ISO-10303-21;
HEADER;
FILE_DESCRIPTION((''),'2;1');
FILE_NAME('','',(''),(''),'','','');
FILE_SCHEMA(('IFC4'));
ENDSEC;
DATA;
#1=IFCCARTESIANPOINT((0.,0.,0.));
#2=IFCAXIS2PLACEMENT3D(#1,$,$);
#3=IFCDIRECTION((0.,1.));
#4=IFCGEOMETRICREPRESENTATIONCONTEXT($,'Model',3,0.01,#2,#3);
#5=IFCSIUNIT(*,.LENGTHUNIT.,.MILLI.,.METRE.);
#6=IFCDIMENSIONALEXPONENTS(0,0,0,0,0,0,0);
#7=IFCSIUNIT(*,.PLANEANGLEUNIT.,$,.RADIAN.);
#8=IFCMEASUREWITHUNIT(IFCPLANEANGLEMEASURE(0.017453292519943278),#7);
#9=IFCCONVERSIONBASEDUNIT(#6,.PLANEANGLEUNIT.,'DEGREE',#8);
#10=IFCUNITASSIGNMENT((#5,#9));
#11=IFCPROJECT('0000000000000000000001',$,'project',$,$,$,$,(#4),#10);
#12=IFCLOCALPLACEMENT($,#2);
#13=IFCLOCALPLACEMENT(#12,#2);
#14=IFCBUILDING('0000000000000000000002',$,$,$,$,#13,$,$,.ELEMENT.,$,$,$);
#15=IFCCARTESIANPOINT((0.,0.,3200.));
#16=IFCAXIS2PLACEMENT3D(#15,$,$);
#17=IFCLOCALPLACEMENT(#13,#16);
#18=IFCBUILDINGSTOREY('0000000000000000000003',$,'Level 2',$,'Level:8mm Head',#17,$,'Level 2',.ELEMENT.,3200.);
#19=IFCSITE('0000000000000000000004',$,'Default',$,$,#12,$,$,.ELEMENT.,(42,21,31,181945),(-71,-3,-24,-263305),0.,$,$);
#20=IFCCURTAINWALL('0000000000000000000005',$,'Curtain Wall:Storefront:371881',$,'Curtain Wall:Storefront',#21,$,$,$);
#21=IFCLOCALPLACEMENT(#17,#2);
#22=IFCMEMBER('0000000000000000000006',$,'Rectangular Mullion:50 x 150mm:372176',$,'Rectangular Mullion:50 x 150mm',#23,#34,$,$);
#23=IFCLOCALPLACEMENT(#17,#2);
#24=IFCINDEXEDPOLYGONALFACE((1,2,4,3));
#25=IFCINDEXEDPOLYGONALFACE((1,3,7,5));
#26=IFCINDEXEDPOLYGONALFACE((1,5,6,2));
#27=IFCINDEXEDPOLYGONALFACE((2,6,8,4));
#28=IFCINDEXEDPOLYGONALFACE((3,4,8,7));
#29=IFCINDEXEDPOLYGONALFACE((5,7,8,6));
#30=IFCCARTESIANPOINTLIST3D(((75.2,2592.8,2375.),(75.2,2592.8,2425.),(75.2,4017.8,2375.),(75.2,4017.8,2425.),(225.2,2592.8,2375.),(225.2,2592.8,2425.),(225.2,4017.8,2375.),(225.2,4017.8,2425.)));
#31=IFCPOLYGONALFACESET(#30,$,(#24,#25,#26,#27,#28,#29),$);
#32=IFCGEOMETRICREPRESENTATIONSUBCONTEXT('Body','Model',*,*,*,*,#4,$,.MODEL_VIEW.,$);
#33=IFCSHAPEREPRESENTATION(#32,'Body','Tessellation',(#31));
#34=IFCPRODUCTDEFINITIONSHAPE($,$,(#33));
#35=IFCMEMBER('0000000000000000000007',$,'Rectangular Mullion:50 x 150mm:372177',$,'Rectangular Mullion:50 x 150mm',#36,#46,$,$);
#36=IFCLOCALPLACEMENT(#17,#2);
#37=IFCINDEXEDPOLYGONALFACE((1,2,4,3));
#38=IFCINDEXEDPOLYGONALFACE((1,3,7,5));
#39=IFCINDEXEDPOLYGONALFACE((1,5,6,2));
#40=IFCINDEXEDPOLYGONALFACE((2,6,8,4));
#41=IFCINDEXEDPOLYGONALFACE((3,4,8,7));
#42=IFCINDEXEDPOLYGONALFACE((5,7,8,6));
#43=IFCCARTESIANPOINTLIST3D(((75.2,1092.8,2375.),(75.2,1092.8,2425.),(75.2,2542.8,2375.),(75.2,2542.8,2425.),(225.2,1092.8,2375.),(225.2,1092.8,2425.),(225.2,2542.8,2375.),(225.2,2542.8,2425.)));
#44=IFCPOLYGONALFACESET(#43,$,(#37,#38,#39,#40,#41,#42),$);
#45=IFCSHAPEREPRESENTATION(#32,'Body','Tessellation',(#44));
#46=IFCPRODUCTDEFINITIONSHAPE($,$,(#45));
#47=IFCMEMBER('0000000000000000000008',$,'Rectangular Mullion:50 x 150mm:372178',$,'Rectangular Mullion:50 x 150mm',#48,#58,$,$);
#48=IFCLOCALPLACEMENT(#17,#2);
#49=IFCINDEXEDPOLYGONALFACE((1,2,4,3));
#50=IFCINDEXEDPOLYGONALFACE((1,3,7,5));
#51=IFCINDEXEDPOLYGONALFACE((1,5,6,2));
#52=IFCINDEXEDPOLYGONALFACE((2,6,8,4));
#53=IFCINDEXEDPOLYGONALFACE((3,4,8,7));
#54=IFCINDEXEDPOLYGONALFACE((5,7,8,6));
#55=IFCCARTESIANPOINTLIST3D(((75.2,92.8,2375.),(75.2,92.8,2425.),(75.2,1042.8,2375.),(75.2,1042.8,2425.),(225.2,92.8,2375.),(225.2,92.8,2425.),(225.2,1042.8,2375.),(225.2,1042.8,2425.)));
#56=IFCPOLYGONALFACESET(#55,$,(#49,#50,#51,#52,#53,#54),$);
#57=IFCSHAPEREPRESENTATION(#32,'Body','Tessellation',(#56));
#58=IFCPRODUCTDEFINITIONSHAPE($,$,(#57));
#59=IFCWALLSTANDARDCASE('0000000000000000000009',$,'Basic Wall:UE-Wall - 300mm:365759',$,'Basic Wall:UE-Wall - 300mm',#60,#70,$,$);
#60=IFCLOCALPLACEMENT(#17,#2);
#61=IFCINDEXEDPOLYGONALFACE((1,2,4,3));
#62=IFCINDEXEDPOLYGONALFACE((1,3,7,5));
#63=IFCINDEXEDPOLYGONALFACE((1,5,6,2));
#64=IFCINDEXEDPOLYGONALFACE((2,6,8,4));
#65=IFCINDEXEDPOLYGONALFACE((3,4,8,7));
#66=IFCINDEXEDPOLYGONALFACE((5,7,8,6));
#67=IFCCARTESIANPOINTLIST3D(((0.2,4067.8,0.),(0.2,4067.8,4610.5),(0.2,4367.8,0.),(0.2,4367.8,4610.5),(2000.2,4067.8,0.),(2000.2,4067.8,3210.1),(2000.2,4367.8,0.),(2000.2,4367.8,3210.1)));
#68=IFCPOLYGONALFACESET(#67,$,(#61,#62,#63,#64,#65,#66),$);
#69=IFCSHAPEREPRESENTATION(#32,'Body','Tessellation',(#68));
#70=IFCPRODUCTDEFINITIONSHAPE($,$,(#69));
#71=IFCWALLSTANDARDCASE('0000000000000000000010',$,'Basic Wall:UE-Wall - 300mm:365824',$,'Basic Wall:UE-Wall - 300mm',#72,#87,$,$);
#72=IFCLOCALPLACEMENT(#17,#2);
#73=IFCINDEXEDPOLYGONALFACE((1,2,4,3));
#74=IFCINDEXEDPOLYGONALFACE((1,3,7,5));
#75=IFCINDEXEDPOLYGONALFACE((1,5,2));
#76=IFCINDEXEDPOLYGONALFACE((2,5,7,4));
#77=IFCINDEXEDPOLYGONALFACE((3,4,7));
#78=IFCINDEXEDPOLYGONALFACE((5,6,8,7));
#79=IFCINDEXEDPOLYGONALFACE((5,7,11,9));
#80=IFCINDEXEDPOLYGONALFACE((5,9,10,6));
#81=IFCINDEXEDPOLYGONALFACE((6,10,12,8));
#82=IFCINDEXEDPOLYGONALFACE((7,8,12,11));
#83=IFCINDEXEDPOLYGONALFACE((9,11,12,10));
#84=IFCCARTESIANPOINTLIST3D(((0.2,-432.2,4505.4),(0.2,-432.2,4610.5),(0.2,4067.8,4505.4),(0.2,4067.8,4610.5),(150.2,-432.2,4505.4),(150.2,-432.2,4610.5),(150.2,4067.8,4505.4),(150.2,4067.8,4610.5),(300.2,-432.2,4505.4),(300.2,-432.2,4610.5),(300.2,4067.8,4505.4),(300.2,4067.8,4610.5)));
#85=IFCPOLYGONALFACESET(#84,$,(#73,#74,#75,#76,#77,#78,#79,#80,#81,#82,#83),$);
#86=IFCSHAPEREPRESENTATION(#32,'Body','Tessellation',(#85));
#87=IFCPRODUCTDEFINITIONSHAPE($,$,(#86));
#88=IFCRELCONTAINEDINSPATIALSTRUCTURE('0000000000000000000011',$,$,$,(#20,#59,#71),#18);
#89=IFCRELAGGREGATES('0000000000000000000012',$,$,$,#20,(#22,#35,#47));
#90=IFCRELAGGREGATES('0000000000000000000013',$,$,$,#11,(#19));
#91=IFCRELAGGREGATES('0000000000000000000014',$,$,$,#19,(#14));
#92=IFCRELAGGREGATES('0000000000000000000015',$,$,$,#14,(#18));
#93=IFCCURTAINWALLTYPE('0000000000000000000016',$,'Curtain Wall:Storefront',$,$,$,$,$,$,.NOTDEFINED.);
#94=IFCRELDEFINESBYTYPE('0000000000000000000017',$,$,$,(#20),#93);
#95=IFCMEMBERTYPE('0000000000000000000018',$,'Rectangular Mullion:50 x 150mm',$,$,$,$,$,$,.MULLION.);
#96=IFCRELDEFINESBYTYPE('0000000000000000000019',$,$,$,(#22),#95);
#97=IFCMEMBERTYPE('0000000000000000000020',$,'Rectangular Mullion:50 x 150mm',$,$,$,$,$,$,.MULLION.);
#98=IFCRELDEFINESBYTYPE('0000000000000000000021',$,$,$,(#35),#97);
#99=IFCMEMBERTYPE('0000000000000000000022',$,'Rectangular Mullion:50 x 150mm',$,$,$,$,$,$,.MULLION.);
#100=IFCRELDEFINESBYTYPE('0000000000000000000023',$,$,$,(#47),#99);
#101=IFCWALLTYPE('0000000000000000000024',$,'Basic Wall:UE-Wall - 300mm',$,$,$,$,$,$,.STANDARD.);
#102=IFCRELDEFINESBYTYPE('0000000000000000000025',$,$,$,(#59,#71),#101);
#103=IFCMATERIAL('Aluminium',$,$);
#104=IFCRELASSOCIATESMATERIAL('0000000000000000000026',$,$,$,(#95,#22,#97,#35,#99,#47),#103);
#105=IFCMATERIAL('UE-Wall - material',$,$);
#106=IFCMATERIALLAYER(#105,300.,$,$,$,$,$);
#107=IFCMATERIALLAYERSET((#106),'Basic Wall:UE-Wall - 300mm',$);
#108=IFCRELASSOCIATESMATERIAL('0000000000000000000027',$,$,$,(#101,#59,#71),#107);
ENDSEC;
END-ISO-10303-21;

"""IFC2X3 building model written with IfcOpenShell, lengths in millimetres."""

from ifc_helpers import new_model, entity, si_unit, converted_unit, direction, frame, frame_2d, origin, origin_2d_with_axis, place, context, subcontext, project, spatial, polyline, rectangle, extrude, clip, bounded_halfspace, source, transform, mapped, material, layer, layer_set, layer_usage, type_object, type_shapes, element, aggregate, save


model = new_model("IFC2X3")

# Units and contexts
model_context = context("Model", 3, precision=0.01, world=origin(), true_north=direction((0.0, 1.0)))
body_context = subcontext(model_context, "Body", "Model", "MODEL_VIEW")
ifc_project = project(units=[si_unit("LENGTHUNIT", "METRE", prefix="MILLI"), converted_unit("PLANEANGLEUNIT", "DEGREE", entity("IfcPlaneAngleMeasure", 0.017453292519943278), si_unit("PLANEANGLEUNIT", "RADIAN"), dimensions=[0, 0, 0, 0, 0, 0, 0])], contexts=[model_context])

# Site, building, storey
site_placement = place(None, origin())
site = spatial("IfcSite", under=ifc_project, at=site_placement, Name="Default", CompositionType="ELEMENT", RefLatitude=(42, 21, 31, 181945), RefLongitude=(-71, -3, -24, -263305), RefElevation=0.0)
building_placement = place(site_placement, origin())
building = spatial("IfcBuilding", under=site, at=building_placement, CompositionType="ELEMENT")
storey_placement = place(building_placement, frame((0.0, 0.0, 3200.0)))
storey = spatial("IfcBuildingStorey", under=building, at=storey_placement, Name="Level 2", ObjectType="Level:8mm Head", LongName="Level 2", CompositionType="ELEMENT", Elevation=3200.0)

# Curtain wall, members
curtain_wall_type = type_object("IfcCurtainWallType", Name="Curtain Wall:Storefront", PredefinedType="NOTDEFINED")
curtain_wall_placement = place(storey_placement, frame((0.0, 0.0, -3200.0)))
curtain_wall = element("IfcCurtainWall", 1, at=curtain_wall_placement, inside=storey, type_object=curtain_wall_type, Name="Curtain Wall:Storefront:371881", ObjectType="Curtain Wall:Storefront")
ifc_material_1 = material(Name="Aluminium")
member_type_1 = type_object("IfcMemberType", Name="Rectangular Mullion:50 x 150mm", PredefinedType="MULLION", material=ifc_material_1)
shared_shape_1 = source(origin(), body_context, "Body", "SweptSolid", [
    extrude(rectangle(XDim=50.0, YDim=150.0, at=origin_2d_with_axis()), frame((0.0, 0.0, -1425.0), z_axis=(0.0, 0.0, 1.0), x_axis=(-1.0, 0.0, 0.0)), (0.0, 0.0, 1.0), 1425.0),
])
type_shapes(member_type_1, [shared_shape_1])
member_1_placement = place(curtain_wall_placement, frame((150.2, 2592.8, 5600.0), z_axis=(0.0, -1.0, 0.0), x_axis=(0.0, 0.0, 1.0)))
member_1 = element("IfcMember", 2, at=member_1_placement, type_object=member_type_1, material=ifc_material_1, Name="Rectangular Mullion:50 x 150mm:372176", ObjectType="Rectangular Mullion:50 x 150mm", context=body_context, shape_type="MappedRepresentation", body=[
    mapped(shared_shape_1, transform((0.0, 0.0, 0.0), scale=1.0)),
])
member_type_2 = type_object("IfcMemberType", Name="Rectangular Mullion:50 x 150mm", PredefinedType="MULLION", material=ifc_material_1)
shared_shape_2 = source(origin(), body_context, "Body", "SweptSolid", [
    extrude(rectangle(XDim=50.0, YDim=150.0, at=origin_2d_with_axis()), frame((0.0, 0.0, -1450.0), z_axis=(0.0, 0.0, 1.0), x_axis=(-1.0, 0.0, 0.0)), (0.0, 0.0, 1.0), 1450.0),
])
type_shapes(member_type_2, [shared_shape_2])
member_2_placement = place(curtain_wall_placement, frame((150.2, 1092.8, 5600.0), z_axis=(0.0, -1.0, 0.0), x_axis=(0.0, 0.0, 1.0)))
member_2 = element("IfcMember", 3, at=member_2_placement, type_object=member_type_2, material=ifc_material_1, Name="Rectangular Mullion:50 x 150mm:372177", ObjectType="Rectangular Mullion:50 x 150mm", context=body_context, shape_type="MappedRepresentation", body=[
    mapped(shared_shape_2, transform((0.0, 0.0, 0.0), scale=1.0)),
])
member_type_3 = type_object("IfcMemberType", Name="Rectangular Mullion:50 x 150mm", PredefinedType="MULLION", material=ifc_material_1)
shared_shape_3 = source(origin(), body_context, "Body", "SweptSolid", [
    extrude(rectangle(XDim=50.0, YDim=150.0, at=origin_2d_with_axis()), frame((0.0, 0.0, -950.0), z_axis=(0.0, 0.0, 1.0), x_axis=(-1.0, 0.0, 0.0)), (0.0, 0.0, 1.0), 950.0),
])
type_shapes(member_type_3, [shared_shape_3])
member_3_placement = place(curtain_wall_placement, frame((150.2, 92.8, 5600.0), z_axis=(0.0, -1.0, 0.0), x_axis=(0.0, 0.0, 1.0)))
member_3 = element("IfcMember", 4, at=member_3_placement, type_object=member_type_3, material=ifc_material_1, Name="Rectangular Mullion:50 x 150mm:372178", ObjectType="Rectangular Mullion:50 x 150mm", context=body_context, shape_type="MappedRepresentation", body=[
    mapped(shared_shape_3, transform((0.0, 0.0, 0.0), scale=1.0)),
])

# Wall
ifc_material_2 = material(Name="UE-Wall - material")
ifc_layer = layer(ifc_material_2, 300.0)
ifc_layer_set = layer_set([ifc_layer], Name="Basic Wall:UE-Wall - 300mm")
ifc_layer_usage_1 = layer_usage(ifc_layer_set, "AXIS2", "NEGATIVE", 150.0)
wall_type = type_object("IfcWallType", Name="Basic Wall:UE-Wall - 300mm", PredefinedType="STANDARD", material=ifc_layer_set)
wall_1_placement = place(storey_placement, frame((2000.2, 4217.8, 0.0), z_axis=(0.0, 0.0, 1.0), x_axis=(-1.0, 0.0, 0.0)))
element("IfcWallStandardCase", 5, at=wall_1_placement, inside=storey, type_object=wall_type, material=ifc_layer_usage_1, Name="Basic Wall:UE-Wall - 300mm:365759", ObjectType="Basic Wall:UE-Wall - 300mm", context=body_context, shape_type="Clipping", body=[
    clip(extrude(rectangle(XDim=2000.0, YDim=300.0, at=frame_2d((1000.0, 0.0), x_axis=(-1.0, 0.0))), origin(), (0.0, 0.0, 1.0), 4610.5), bounded_halfspace(frame((0.0, -150.0, 3210.1), z_axis=(-0.573576, 0.0, 0.819152), x_axis=(0.0, -1.0, 0.0)), False, frame((0.0, -150.0, 3210.1)), polyline([(0.0, 0.0), (1850.0, 0.0), (2000.0, 0.0), (2000.0, 300.0), (1850.0, 300.0), (1775.0, 300.0), (0.0, 300.0), (0.0, 0.0)]))),
])

# Wall, opening
ifc_layer_usage_2 = layer_usage(ifc_layer_set, "AXIS2", "NEGATIVE", 150.0)
wall_2_placement = place(storey_placement, frame((150.2, 4067.8, 4505.4), z_axis=(0.0, 0.0, 1.0), x_axis=(0.0, -1.0, 0.0)))
wall_2 = element("IfcWallStandardCase", 6, at=wall_2_placement, inside=storey, type_object=wall_type, material=ifc_layer_usage_2, Name="Basic Wall:UE-Wall - 300mm:365824", ObjectType="Basic Wall:UE-Wall - 300mm", context=body_context, shape_type="Clipping", body=[
    clip(extrude(rectangle(XDim=4500.0, YDim=300.0, at=frame_2d((2250.0, 0.0), x_axis=(-1.0, 0.0))), origin(), (0.0, 0.0, 1.0), 105.0), bounded_halfspace(frame((0.0, -150.0, 105.0), z_axis=(0.0, 0.573576, 0.819152), x_axis=(-1.0, 0.0, 0.0)), False, frame((0.0, -150.0, 105.0)), polyline([(0.0, 0.0), (4500.0, 0.0), (4500.0, 150.0), (0.0, 150.0), (0.0, 0.0)]))),
])
opening_placement = place(wall_2_placement, origin())
element("IfcOpeningElement", 7, at=opening_placement, cuts=wall_2, ObjectType="Opening", context=body_context, shape_type="SweptSolid", body=[
    extrude(rectangle(XDim=4505.4, YDim=4500.0, at=frame_2d((0.0, 0.0), x_axis=(1.0, 0.0))), frame((2250.0, -302.4, -2252.7), z_axis=(0.0, 1.0, 0.0), x_axis=(0.0, 0.0, 1.0)), (0.0, 0.0, 1.0), 604.8),
])

aggregate(curtain_wall, [member_1, member_2, member_3])

save(model, "model.ifc")
